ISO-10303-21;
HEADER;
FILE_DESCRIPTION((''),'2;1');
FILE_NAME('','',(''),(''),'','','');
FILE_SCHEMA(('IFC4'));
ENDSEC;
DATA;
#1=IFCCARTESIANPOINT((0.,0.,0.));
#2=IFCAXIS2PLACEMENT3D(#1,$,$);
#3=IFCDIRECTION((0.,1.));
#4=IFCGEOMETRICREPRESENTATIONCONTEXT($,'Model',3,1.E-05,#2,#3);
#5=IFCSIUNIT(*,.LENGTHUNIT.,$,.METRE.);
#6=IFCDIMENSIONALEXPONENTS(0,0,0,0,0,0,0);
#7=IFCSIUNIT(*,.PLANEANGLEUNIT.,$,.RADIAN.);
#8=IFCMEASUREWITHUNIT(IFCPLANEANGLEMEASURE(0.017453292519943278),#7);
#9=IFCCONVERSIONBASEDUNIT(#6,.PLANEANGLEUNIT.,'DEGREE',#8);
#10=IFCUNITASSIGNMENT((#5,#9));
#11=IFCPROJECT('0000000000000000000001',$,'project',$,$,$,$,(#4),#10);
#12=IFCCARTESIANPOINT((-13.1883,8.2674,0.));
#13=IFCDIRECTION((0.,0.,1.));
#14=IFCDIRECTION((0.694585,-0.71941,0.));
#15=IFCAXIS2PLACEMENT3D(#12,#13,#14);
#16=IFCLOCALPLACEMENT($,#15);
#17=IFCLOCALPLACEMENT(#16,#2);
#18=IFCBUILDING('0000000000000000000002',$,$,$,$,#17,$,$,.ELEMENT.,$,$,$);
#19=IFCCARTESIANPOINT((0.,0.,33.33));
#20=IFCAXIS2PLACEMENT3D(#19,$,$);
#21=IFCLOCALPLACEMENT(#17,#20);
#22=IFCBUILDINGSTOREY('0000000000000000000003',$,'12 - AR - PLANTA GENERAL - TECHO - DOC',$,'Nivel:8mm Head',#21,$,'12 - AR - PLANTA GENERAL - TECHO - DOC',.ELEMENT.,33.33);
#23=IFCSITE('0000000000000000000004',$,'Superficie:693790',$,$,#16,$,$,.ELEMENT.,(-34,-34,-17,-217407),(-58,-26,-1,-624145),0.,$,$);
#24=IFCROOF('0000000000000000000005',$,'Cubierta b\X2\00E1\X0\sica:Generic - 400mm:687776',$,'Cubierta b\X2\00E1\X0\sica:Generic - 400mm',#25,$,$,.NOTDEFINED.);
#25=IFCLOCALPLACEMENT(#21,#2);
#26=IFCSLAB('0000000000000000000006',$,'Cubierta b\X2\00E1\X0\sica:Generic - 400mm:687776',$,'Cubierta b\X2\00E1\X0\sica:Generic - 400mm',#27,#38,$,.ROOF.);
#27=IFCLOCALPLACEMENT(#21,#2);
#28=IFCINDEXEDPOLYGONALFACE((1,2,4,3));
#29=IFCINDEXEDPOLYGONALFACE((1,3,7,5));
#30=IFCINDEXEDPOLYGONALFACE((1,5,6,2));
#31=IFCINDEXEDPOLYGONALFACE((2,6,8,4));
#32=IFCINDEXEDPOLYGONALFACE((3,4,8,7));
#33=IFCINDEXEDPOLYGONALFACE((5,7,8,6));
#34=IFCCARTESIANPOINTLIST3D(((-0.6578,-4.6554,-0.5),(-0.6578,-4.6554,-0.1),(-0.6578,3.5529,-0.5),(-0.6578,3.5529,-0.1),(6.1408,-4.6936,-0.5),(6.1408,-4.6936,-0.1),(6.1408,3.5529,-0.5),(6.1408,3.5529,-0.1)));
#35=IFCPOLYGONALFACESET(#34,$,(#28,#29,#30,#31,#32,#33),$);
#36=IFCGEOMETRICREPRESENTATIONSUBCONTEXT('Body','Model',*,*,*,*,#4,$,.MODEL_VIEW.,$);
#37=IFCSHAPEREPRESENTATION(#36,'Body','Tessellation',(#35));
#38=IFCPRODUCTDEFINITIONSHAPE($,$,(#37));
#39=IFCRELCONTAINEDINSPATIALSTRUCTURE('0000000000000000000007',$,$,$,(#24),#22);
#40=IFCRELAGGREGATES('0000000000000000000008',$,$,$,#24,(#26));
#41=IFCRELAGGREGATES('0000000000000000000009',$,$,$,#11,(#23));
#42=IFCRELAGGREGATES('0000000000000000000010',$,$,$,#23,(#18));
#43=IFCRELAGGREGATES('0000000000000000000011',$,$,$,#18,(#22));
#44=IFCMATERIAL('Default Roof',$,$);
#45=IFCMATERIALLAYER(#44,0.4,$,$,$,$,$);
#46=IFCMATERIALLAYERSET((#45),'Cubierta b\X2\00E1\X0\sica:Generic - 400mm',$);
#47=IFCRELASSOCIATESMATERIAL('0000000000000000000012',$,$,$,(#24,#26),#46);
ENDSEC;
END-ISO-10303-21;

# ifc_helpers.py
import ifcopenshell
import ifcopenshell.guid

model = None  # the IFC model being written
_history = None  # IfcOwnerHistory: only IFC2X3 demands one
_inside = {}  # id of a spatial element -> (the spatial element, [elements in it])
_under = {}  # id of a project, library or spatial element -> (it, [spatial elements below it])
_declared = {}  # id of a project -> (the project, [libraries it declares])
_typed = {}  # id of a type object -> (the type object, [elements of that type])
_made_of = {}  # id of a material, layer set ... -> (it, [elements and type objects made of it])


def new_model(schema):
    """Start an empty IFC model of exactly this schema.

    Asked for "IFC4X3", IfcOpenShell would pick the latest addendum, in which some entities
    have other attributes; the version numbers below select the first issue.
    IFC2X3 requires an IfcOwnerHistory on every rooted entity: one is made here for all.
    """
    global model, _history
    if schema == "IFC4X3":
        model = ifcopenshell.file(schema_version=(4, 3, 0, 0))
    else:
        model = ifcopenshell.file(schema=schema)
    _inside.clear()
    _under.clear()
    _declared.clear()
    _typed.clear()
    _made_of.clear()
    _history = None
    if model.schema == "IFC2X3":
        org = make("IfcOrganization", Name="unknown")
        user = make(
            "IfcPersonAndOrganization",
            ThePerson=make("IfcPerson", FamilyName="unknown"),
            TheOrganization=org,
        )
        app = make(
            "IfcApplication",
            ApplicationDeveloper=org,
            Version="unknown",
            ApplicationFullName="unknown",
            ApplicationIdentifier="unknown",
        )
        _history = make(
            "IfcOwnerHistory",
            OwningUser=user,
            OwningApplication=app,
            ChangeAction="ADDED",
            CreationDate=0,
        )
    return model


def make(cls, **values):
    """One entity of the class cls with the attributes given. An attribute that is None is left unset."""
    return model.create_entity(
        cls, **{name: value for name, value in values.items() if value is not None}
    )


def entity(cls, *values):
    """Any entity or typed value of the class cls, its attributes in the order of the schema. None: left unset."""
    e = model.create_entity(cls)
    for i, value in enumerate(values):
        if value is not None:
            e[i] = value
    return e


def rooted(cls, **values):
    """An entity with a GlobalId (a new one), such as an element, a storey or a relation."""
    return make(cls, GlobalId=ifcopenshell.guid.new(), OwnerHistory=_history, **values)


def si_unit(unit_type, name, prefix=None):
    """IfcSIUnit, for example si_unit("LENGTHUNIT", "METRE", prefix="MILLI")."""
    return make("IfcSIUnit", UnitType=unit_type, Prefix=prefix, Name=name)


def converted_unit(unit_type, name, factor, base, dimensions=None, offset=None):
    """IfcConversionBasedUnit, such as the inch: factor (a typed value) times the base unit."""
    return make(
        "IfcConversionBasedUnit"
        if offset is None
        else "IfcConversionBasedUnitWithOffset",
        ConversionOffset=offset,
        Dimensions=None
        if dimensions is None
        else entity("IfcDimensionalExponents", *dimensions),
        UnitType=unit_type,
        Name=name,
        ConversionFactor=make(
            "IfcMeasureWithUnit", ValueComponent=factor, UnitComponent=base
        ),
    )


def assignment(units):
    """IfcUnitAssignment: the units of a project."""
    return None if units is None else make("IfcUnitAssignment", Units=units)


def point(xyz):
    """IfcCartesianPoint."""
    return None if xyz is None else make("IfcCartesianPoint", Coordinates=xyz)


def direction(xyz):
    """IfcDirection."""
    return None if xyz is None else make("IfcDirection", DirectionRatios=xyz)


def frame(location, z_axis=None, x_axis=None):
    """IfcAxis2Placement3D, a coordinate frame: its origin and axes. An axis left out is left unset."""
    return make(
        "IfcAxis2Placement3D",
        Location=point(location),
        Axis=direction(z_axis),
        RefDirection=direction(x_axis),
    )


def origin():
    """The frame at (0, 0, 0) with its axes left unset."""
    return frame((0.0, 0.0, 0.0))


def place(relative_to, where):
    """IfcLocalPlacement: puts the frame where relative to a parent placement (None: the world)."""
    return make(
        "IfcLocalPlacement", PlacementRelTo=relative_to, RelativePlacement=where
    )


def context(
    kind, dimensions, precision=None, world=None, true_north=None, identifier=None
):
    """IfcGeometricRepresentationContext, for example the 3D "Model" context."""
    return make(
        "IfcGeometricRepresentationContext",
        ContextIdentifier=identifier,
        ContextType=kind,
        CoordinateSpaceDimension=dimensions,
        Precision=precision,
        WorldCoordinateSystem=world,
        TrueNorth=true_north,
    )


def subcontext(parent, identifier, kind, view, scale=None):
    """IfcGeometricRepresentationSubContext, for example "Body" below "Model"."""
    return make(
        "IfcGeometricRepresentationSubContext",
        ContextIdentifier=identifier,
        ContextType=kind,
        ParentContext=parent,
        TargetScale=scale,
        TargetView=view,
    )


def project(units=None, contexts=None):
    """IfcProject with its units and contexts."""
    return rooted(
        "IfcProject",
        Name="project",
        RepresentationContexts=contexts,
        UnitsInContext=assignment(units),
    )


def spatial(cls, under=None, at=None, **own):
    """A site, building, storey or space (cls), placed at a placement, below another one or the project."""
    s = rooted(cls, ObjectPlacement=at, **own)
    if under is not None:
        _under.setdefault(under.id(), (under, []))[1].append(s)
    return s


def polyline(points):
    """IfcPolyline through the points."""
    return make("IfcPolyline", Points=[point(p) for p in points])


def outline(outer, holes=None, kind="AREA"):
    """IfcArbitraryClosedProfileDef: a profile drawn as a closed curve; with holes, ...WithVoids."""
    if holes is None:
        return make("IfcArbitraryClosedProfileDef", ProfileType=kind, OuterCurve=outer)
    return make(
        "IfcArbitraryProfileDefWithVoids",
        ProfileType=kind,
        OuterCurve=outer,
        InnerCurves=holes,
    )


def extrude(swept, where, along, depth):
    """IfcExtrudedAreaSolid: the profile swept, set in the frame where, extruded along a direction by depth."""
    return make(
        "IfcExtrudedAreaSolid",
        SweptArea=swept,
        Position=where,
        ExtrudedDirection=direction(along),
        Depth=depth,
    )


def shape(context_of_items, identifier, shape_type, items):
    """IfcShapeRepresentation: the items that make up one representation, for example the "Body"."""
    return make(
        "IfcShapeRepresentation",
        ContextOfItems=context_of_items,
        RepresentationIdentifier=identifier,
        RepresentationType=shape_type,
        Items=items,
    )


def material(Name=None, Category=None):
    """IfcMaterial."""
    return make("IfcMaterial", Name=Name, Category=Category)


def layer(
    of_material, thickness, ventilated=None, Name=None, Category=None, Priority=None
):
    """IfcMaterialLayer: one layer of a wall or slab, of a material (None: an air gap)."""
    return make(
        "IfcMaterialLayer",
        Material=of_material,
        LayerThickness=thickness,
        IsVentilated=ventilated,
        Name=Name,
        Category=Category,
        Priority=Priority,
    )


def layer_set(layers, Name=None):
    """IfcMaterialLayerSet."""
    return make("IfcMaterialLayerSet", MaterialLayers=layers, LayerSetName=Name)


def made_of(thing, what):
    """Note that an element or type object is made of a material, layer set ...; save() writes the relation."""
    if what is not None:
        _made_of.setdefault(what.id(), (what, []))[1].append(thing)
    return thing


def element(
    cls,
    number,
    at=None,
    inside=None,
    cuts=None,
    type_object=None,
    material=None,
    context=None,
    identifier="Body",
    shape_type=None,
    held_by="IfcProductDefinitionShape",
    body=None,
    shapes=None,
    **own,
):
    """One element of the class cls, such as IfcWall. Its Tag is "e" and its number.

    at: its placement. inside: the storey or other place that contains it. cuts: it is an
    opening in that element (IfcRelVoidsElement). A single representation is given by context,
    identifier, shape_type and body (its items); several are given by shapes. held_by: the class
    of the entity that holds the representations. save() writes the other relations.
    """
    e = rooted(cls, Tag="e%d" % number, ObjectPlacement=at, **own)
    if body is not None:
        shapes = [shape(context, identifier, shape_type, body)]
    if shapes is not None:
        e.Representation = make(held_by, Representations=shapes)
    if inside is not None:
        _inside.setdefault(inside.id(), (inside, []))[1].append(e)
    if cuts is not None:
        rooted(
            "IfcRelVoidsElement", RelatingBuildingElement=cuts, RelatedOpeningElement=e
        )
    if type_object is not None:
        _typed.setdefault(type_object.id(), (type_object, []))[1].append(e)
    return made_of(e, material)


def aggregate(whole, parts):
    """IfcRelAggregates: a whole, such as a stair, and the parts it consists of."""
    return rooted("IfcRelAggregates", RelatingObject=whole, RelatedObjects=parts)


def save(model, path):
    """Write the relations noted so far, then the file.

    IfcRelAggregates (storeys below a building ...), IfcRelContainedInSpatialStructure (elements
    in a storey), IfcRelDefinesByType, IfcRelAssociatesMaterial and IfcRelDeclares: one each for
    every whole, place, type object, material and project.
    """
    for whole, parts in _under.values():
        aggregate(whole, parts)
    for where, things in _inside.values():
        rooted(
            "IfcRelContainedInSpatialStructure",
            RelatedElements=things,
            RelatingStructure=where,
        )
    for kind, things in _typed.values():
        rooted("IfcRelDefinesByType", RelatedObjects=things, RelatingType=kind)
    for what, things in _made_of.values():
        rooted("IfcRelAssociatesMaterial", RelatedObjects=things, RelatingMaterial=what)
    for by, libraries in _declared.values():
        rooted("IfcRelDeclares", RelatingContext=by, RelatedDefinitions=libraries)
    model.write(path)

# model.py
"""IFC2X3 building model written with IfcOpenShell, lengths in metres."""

from ifc_helpers import new_model, entity, si_unit, converted_unit, direction, frame, origin, place, context, subcontext, project, spatial, polyline, outline, extrude, material, layer, layer_set, element, aggregate, save


model = new_model("IFC2X3")

# Units and contexts
model_context = context("Model", 3, precision=1e-05, world=origin(), true_north=direction((0.0, 1.0)))
body_context = subcontext(model_context, "Body", "Model", "MODEL_VIEW")
ifc_project = project(units=[si_unit("LENGTHUNIT", "METRE"), converted_unit("PLANEANGLEUNIT", "DEGREE", entity("IfcPlaneAngleMeasure", 0.017453292519943278), si_unit("PLANEANGLEUNIT", "RADIAN"), dimensions=[0, 0, 0, 0, 0, 0, 0])], contexts=[model_context])

# Site, building, storey
site_placement = place(None, frame((-13.1883, 8.2674, 0.0), z_axis=(0.0, 0.0, 1.0), x_axis=(0.694585, -0.71941, 0.0)))
site = spatial("IfcSite", under=ifc_project, at=site_placement, Name="Superficie:693790", CompositionType="ELEMENT", RefLatitude=(-34, -34, -17, -217407), RefLongitude=(-58, -26, -1, -624145), RefElevation=0.0)
building_placement = place(site_placement, origin())
building = spatial("IfcBuilding", under=site, at=building_placement, CompositionType="ELEMENT")
storey_placement = place(building_placement, frame((0.0, 0.0, 33.33)))
storey = spatial("IfcBuildingStorey", under=building, at=storey_placement, Name="12 - AR - PLANTA GENERAL - TECHO - DOC", ObjectType="Nivel:8mm Head", LongName="12 - AR - PLANTA GENERAL - TECHO - DOC", CompositionType="ELEMENT", Elevation=33.33)

# Roof, slab
ifc_material = material(Name="Default Roof")
ifc_layer = layer(ifc_material, 0.4)
ifc_layer_set = layer_set([ifc_layer], Name="Cubierta básica:Generic - 400mm")
roof_placement = place(storey_placement, frame((-0.6578, -4.6936, -0.5)))
roof = element("IfcRoof", 1, at=roof_placement, inside=storey, material=ifc_layer_set, Name="Cubierta básica:Generic - 400mm:687776", ObjectType="Cubierta básica:Generic - 400mm", ShapeType="NOTDEFINED")
slab_placement = place(roof_placement, origin())
slab = element("IfcSlab", 2, at=slab_placement, material=ifc_layer_set, Name="Cubierta básica:Generic - 400mm:687776", ObjectType="Cubierta básica:Generic - 400mm", PredefinedType="ROOF", context=body_context, shape_type="SweptSolid", body=[
    extrude(outline(polyline([(3.3993, -4.1232), (3.3993, 4.1232), (-3.3993, 4.1232), (-3.3993, -4.085), (3.3993, -4.1232)])), frame((3.3993, 4.1232, 0.0)), (0.0, 0.0, 1.0), 0.4),
])
aggregate(roof, [slab])

save(model, "model.ifc")
